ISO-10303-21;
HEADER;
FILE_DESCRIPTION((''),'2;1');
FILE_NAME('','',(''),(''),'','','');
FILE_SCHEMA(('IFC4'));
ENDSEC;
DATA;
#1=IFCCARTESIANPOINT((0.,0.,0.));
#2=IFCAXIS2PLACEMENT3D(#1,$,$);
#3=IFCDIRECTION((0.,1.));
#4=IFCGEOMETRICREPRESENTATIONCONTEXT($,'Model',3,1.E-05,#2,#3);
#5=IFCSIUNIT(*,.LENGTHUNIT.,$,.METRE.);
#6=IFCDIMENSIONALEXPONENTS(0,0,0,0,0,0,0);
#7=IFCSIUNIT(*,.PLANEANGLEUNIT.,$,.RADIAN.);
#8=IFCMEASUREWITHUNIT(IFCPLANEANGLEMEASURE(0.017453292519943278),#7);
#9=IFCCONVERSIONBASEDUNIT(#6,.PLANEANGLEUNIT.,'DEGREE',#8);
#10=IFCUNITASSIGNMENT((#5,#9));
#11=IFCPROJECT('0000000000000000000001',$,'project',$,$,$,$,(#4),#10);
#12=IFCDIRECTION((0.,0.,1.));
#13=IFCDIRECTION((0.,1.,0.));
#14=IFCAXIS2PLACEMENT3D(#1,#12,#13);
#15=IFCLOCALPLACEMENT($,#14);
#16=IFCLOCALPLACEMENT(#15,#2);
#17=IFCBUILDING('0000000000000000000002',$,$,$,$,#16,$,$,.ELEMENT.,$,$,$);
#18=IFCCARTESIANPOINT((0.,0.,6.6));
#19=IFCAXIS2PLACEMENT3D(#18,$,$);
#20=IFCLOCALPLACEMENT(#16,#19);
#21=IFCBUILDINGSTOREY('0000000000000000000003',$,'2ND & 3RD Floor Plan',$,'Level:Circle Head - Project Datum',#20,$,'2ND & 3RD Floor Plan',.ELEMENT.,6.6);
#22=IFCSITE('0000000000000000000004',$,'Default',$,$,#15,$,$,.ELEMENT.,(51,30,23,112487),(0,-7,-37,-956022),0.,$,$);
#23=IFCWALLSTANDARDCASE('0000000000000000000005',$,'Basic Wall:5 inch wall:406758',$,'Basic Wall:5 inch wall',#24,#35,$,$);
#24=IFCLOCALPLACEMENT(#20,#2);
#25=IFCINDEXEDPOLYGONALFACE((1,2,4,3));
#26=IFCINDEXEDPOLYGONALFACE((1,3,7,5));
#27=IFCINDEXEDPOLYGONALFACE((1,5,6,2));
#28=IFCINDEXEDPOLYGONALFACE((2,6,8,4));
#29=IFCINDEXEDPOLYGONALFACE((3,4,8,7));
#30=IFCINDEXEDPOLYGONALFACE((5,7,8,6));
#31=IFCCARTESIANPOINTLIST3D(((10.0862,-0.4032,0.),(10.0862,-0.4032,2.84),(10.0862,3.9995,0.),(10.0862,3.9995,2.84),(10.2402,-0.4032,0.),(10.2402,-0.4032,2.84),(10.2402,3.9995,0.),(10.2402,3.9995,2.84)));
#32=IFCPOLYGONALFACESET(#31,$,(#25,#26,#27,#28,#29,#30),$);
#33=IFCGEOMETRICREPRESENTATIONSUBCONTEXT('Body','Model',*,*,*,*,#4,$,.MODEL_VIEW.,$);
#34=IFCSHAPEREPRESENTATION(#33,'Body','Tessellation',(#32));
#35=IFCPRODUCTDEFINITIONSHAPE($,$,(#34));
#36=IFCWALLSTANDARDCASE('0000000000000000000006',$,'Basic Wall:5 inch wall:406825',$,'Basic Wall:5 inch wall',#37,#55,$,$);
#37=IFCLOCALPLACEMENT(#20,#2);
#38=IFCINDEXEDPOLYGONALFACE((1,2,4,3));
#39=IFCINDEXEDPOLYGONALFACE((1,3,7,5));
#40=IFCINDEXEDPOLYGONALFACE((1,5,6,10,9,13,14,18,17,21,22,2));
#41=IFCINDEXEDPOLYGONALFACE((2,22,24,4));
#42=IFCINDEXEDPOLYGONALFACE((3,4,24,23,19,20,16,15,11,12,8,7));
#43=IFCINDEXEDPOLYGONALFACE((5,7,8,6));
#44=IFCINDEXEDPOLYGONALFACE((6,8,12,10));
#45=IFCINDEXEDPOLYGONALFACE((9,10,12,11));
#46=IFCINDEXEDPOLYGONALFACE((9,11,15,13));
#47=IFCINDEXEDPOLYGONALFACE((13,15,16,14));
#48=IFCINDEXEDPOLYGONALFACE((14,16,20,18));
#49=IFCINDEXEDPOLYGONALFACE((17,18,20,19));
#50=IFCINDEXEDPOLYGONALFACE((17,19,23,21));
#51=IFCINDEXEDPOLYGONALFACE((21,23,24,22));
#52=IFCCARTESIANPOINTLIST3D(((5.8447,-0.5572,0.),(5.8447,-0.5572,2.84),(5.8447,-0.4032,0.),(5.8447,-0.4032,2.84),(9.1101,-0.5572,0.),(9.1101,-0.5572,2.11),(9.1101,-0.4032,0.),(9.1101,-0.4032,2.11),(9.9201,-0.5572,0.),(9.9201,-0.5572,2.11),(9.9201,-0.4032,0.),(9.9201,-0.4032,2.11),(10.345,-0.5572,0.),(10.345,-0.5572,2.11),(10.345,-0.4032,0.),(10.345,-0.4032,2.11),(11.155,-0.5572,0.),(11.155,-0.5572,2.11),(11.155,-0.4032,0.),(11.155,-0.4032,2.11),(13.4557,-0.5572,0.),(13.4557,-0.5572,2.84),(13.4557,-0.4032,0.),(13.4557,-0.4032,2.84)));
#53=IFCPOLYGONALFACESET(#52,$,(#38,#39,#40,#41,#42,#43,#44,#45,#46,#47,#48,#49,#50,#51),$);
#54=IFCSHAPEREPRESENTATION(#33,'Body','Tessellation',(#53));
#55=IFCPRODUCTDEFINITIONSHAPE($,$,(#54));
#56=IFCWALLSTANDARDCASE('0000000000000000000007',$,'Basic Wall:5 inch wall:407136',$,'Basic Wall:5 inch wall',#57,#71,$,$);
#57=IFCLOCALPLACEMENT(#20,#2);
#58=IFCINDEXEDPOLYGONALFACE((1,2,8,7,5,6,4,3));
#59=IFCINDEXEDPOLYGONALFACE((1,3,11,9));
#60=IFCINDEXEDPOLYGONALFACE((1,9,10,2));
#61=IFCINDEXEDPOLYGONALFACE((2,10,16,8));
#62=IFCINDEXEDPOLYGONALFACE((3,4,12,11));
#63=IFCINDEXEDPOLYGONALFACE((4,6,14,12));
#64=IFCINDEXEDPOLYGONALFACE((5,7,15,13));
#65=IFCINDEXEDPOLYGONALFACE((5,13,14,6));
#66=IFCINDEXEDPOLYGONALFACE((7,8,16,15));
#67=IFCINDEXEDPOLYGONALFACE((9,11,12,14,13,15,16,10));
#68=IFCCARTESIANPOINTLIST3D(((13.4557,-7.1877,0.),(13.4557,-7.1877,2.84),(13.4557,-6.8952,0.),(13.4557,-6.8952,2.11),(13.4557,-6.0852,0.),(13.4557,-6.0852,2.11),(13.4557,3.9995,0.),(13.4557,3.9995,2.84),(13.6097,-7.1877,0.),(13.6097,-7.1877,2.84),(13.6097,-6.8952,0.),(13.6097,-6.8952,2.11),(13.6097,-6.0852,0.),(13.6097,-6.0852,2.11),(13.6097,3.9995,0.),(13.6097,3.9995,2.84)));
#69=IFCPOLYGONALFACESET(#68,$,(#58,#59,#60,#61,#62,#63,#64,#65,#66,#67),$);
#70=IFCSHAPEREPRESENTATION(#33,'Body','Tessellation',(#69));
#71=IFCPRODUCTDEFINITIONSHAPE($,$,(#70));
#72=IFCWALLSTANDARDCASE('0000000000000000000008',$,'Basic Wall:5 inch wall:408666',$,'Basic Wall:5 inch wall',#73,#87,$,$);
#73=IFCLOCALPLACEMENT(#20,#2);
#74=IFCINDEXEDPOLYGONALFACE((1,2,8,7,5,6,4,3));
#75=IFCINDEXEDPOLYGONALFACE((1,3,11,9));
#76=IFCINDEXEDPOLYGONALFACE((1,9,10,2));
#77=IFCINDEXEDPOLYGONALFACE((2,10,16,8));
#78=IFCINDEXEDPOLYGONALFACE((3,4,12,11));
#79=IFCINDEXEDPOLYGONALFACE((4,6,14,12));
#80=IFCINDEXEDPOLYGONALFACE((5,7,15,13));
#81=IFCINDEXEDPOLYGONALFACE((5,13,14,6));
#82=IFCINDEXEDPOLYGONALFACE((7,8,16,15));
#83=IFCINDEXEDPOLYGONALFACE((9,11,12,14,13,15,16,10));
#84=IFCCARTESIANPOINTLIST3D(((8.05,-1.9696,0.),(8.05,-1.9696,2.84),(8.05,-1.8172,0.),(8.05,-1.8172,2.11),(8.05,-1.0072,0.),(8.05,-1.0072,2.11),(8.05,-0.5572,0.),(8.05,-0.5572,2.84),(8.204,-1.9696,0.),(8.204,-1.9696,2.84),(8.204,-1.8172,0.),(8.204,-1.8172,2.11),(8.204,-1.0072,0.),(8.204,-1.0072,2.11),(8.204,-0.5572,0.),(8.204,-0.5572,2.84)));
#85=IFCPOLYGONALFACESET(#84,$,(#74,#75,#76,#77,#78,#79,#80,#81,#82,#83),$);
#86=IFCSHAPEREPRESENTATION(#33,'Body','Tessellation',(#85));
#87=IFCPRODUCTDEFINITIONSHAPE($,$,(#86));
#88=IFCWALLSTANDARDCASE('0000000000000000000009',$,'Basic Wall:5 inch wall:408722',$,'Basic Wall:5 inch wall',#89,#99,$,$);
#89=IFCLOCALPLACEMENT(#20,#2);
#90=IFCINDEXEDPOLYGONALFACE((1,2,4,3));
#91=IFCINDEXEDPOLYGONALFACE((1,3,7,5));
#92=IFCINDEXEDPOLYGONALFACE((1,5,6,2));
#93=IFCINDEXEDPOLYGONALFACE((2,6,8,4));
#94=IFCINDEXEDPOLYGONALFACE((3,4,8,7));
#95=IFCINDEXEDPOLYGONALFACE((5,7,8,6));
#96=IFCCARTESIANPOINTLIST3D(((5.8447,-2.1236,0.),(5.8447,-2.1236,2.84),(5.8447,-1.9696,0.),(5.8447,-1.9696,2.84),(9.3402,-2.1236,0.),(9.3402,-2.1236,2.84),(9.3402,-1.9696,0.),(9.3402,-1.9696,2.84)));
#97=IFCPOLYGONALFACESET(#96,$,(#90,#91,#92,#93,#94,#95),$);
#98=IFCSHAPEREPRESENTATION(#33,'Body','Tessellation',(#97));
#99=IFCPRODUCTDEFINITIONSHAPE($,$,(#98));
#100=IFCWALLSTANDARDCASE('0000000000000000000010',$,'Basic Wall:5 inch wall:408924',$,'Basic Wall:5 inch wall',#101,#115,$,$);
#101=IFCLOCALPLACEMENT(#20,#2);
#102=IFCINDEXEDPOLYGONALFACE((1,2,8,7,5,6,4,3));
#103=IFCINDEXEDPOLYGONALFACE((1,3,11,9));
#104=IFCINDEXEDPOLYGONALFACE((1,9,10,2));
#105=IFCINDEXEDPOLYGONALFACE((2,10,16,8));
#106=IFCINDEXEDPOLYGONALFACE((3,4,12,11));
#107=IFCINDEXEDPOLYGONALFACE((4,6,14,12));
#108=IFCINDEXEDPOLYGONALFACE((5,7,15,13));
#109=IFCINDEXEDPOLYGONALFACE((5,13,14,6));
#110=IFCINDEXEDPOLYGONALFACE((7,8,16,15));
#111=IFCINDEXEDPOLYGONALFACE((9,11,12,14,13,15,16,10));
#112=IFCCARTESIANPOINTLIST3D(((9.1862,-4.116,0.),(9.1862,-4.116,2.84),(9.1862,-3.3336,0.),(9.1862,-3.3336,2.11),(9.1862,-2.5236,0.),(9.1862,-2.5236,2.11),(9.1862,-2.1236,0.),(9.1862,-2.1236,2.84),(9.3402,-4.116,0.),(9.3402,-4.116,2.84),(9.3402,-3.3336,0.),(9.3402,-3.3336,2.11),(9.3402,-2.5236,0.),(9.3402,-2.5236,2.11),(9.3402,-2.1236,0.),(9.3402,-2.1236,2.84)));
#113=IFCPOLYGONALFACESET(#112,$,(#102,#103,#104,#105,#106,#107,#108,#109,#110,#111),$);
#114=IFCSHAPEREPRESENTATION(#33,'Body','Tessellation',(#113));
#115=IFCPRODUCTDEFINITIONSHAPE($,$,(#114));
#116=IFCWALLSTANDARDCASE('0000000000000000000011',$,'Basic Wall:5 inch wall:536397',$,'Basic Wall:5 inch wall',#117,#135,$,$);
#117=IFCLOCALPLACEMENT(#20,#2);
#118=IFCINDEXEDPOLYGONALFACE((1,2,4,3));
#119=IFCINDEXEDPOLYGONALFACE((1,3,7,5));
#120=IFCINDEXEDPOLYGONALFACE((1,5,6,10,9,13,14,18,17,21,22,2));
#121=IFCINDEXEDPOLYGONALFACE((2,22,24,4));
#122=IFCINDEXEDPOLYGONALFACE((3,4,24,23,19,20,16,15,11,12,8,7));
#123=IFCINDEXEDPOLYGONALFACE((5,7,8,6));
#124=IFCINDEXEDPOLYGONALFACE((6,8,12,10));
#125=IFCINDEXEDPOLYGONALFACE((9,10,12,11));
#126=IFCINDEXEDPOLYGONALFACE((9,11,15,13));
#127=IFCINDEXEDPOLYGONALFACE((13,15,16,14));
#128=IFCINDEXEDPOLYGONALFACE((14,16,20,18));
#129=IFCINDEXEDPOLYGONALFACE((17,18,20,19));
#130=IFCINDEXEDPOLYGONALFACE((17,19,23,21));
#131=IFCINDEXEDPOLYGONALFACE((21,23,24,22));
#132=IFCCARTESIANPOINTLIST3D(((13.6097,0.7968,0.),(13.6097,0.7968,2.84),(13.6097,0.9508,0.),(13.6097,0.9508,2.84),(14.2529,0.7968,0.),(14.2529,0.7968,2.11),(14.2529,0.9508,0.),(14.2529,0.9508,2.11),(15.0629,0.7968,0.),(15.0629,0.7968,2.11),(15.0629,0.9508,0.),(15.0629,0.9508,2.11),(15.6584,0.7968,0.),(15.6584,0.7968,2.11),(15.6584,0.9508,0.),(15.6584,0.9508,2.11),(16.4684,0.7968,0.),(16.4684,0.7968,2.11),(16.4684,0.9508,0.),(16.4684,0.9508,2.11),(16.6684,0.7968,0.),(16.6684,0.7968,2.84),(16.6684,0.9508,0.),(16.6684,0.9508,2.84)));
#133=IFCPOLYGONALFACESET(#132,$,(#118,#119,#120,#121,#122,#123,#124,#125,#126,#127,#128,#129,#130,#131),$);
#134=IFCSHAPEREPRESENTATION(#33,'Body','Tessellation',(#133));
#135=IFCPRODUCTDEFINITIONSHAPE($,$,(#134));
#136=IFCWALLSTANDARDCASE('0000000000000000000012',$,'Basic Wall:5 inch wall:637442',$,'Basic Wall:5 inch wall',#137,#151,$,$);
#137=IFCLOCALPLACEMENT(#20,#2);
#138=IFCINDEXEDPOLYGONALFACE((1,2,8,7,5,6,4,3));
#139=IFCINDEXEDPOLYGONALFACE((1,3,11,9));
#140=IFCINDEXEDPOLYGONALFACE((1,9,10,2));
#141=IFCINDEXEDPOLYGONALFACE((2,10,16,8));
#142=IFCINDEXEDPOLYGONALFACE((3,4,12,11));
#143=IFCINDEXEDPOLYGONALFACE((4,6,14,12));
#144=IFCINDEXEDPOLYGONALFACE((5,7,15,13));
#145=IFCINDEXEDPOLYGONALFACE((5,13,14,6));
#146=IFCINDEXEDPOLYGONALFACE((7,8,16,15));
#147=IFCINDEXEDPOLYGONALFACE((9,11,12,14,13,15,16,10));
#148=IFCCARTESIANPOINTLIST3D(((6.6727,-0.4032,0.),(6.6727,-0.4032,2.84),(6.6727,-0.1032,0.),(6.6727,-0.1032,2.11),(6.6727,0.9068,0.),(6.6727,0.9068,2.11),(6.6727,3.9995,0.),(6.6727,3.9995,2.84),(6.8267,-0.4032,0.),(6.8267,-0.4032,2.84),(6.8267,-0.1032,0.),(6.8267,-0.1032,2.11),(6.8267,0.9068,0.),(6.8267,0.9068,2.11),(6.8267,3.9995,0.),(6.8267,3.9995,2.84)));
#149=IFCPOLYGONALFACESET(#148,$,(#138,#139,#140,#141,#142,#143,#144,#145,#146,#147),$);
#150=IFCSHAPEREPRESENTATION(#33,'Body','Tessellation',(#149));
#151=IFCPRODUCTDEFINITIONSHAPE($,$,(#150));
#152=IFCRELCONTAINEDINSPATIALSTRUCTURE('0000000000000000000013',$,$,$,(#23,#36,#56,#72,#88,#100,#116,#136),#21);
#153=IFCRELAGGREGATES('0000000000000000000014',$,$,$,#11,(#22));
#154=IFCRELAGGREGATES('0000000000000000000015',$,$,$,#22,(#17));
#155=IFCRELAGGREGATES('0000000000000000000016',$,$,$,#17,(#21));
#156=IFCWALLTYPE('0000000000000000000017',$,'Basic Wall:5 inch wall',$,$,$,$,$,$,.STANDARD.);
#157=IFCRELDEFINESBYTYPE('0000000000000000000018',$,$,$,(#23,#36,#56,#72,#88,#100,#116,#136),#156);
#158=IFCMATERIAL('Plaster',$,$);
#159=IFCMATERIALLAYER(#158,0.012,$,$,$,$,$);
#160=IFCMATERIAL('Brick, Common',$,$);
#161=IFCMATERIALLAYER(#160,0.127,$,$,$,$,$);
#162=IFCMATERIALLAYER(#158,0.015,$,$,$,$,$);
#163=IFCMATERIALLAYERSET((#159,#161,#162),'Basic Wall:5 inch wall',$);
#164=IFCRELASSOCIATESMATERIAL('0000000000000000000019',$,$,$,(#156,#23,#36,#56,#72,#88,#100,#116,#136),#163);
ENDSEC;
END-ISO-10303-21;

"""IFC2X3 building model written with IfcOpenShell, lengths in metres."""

from ifc_helpers import new_model, entity, si_unit, converted_unit, direction, frame, frame_2d, origin, place, context, subcontext, project, spatial, rectangle, extrude, material, layer, layer_set, layer_usage, type_object, element, save


model = new_model("IFC2X3")

# Units and contexts
model_context = context("Model", 3, precision=1e-05, world=origin(), true_north=direction((0.0, 1.0)))
body_context = subcontext(model_context, "Body", "Model", "MODEL_VIEW")
ifc_project = project(units=[si_unit("LENGTHUNIT", "METRE"), converted_unit("PLANEANGLEUNIT", "DEGREE", entity("IfcPlaneAngleMeasure", 0.017453292519943278), si_unit("PLANEANGLEUNIT", "RADIAN"), dimensions=[0, 0, 0, 0, 0, 0, 0])], contexts=[model_context])

# Site, building, storey
site_placement = place(None, frame((0.0, 0.0, 0.0), z_axis=(0.0, 0.0, 1.0), x_axis=(0.0, 1.0, 0.0)))
site = spatial("IfcSite", under=ifc_project, at=site_placement, Name="Default", CompositionType="ELEMENT", RefLatitude=(51, 30, 23, 112487), RefLongitude=(0, -7, -37, -956022), RefElevation=0.0)
building_placement = place(site_placement, origin())
building = spatial("IfcBuilding", under=site, at=building_placement, CompositionType="ELEMENT")
storey_placement = place(building_placement, frame((0.0, 0.0, 6.6)))
storey = spatial("IfcBuildingStorey", under=building, at=storey_placement, Name="2ND & 3RD Floor Plan", ObjectType="Level:Circle Head - Project Datum", LongName="2ND & 3RD Floor Plan", CompositionType="ELEMENT", Elevation=6.6)

# Wall
ifc_material_1 = material(Name="Plaster")
ifc_layer_1 = layer(ifc_material_1, 0.012)
ifc_material_2 = material(Name="Brick, Common")
ifc_layer_2 = layer(ifc_material_2, 0.127)
ifc_layer_3 = layer(ifc_material_1, 0.015)
ifc_layer_set = layer_set([ifc_layer_1, ifc_layer_2, ifc_layer_3], Name="Basic Wall:5 inch wall")
ifc_layer_usage_1 = layer_usage(ifc_layer_set, "AXIS2", "NEGATIVE", 0.077)
wall_type = type_object("IfcWallType", Name="Basic Wall:5 inch wall", PredefinedType="STANDARD", material=ifc_layer_set)
wall_1_placement = place(storey_placement, frame((10.1632, 3.9995, 0.0), z_axis=(0.0, 0.0, 1.0), x_axis=(0.0, -1.0, 0.0)))
element("IfcWallStandardCase", 1, at=wall_1_placement, inside=storey, type_object=wall_type, material=ifc_layer_usage_1, Name="Basic Wall:5 inch wall:406758", ObjectType="Basic Wall:5 inch wall", context=body_context, shape_type="SweptSolid", body=[
    extrude(rectangle(XDim=4.4027, YDim=0.154, at=frame_2d((2.2014, 0.0), x_axis=(-1.0, 0.0))), origin(), (0.0, 0.0, 1.0), 2.84),
])

# Wall, openings
ifc_layer_usage_2 = layer_usage(ifc_layer_set, "AXIS2", "NEGATIVE", 0.077)
wall_2_placement = place(storey_placement, frame((13.4557, -0.4802, 0.0), z_axis=(0.0, 0.0, 1.0), x_axis=(-1.0, 0.0, 0.0)))
wall_2 = element("IfcWallStandardCase", 2, at=wall_2_placement, inside=storey, type_object=wall_type, material=ifc_layer_usage_2, Name="Basic Wall:5 inch wall:406825", ObjectType="Basic Wall:5 inch wall", context=body_context, shape_type="SweptSolid", body=[
    extrude(rectangle(XDim=7.611, YDim=0.154, at=frame_2d((3.8055, 0.0), x_axis=(-1.0, 0.0))), origin(), (0.0, 0.0, 1.0), 2.84),
])
opening_1_placement = place(wall_2_placement, frame((4.3456, 0.077, 0.0)))
element("IfcOpeningElement", 3, at=opening_1_placement, cuts=wall_2, ObjectType="Opening", context=body_context, shape_type="SweptSolid", body=[
    extrude(rectangle(XDim=2.11, YDim=0.81, at=frame_2d((1.055, 0.405), x_axis=(1.0, 0.0))), frame((0.0, 0.0, 0.0), z_axis=(0.0, -1.0, 0.0), x_axis=(0.0, 0.0, 1.0)), (0.0, 0.0, 1.0), 0.154),
])
opening_2_placement = place(wall_2_placement, frame((3.1107, 0.077, 0.0)))
element("IfcOpeningElement", 4, at=opening_2_placement, cuts=wall_2, ObjectType="Opening", context=body_context, shape_type="SweptSolid", body=[
    extrude(rectangle(XDim=2.11, YDim=0.81, at=frame_2d((1.055, 0.405), x_axis=(1.0, 0.0))), frame((0.0, 0.0, 0.0), z_axis=(0.0, -1.0, 0.0), x_axis=(0.0, 0.0, 1.0)), (0.0, 0.0, 1.0), 0.154),
])

# Walls, openings
ifc_layer_usage_3 = layer_usage(ifc_layer_set, "AXIS2", "NEGATIVE", 0.077)
wall_3_placement = place(storey_placement, frame((13.5327, 3.9995, 0.0), z_axis=(0.0, 0.0, 1.0), x_axis=(0.0, -1.0, 0.0)))
wall_3 = element("IfcWallStandardCase", 5, at=wall_3_placement, inside=storey, type_object=wall_type, material=ifc_layer_usage_3, Name="Basic Wall:5 inch wall:407136", ObjectType="Basic Wall:5 inch wall", context=body_context, shape_type="SweptSolid", body=[
    extrude(rectangle(XDim=11.1872, YDim=0.154, at=frame_2d((5.5936, 0.0), x_axis=(-1.0, 0.0))), origin(), (0.0, 0.0, 1.0), 2.84),
])
opening_3_placement = place(wall_3_placement, frame((10.0847, -0.077, 0.0)))
element("IfcOpeningElement", 6, at=opening_3_placement, cuts=wall_3, ObjectType="Opening", context=body_context, shape_type="SweptSolid", body=[
    extrude(rectangle(XDim=2.11, YDim=0.81, at=frame_2d((1.055, 0.405), x_axis=(1.0, 0.0))), frame((0.0, 0.0, 0.0), z_axis=(0.0, 1.0, 0.0), x_axis=(0.0, 0.0, 1.0)), (0.0, 0.0, 1.0), 0.154),
])
ifc_layer_usage_4 = layer_usage(ifc_layer_set, "AXIS2", "NEGATIVE", 0.077)
wall_4_placement = place(storey_placement, frame((8.127, -0.5572, 0.0), z_axis=(0.0, 0.0, 1.0), x_axis=(0.0, -1.0, 0.0)))
wall_4 = element("IfcWallStandardCase", 7, at=wall_4_placement, inside=storey, type_object=wall_type, material=ifc_layer_usage_4, Name="Basic Wall:5 inch wall:408666", ObjectType="Basic Wall:5 inch wall", context=body_context, shape_type="SweptSolid", body=[
    extrude(rectangle(XDim=1.4124, YDim=0.154, at=frame_2d((0.7062, 0.0), x_axis=(-1.0, 0.0))), origin(), (0.0, 0.0, 1.0), 2.84),
])
opening_4_placement = place(wall_4_placement, frame((1.26, 0.077, 0.0)))
element("IfcOpeningElement", 8, at=opening_4_placement, cuts=wall_4, ObjectType="Opening", context=body_context, shape_type="SweptSolid", body=[
    extrude(rectangle(XDim=2.11, YDim=0.81, at=frame_2d((1.055, 0.405), x_axis=(1.0, 0.0))), frame((0.0, 0.0, 0.0), z_axis=(0.0, -1.0, 0.0), x_axis=(0.0, 0.0, 1.0)), (0.0, 0.0, 1.0), 0.154),
])

# Wall
ifc_layer_usage_5 = layer_usage(ifc_layer_set, "AXIS2", "NEGATIVE", 0.077)
wall_5_placement = place(storey_placement, frame((9.3402, -2.0466, 0.0), z_axis=(0.0, 0.0, 1.0), x_axis=(-1.0, 0.0, 0.0)))
element("IfcWallStandardCase", 9, at=wall_5_placement, inside=storey, type_object=wall_type, material=ifc_layer_usage_5, Name="Basic Wall:5 inch wall:408722", ObjectType="Basic Wall:5 inch wall", context=body_context, shape_type="SweptSolid", body=[
    extrude(rectangle(XDim=3.4955, YDim=0.154, at=frame_2d((1.7478, 0.0), x_axis=(-1.0, 0.0))), origin(), (0.0, 0.0, 1.0), 2.84),
])

# Wall, opening
ifc_layer_usage_6 = layer_usage(ifc_layer_set, "AXIS2", "NEGATIVE", 0.077)
wall_6_placement = place(storey_placement, frame((9.2632, -2.1236, 0.0), z_axis=(0.0, 0.0, 1.0), x_axis=(0.0, -1.0, 0.0)))
wall_6 = element("IfcWallStandardCase", 10, at=wall_6_placement, inside=storey, type_object=wall_type, material=ifc_layer_usage_6, Name="Basic Wall:5 inch wall:408924", ObjectType="Basic Wall:5 inch wall", context=body_context, shape_type="SweptSolid", body=[
    extrude(rectangle(XDim=1.9924, YDim=0.154, at=frame_2d((0.9962, 0.0), x_axis=(-1.0, 0.0))), origin(), (0.0, 0.0, 1.0), 2.84),
])
opening_5_placement = place(wall_6_placement, frame((1.21, 0.077, 0.0)))
element("IfcOpeningElement", 11, at=opening_5_placement, cuts=wall_6, ObjectType="Opening", context=body_context, shape_type="SweptSolid", body=[
    extrude(rectangle(XDim=2.11, YDim=0.81, at=frame_2d((1.055, 0.405), x_axis=(1.0, 0.0))), frame((0.0, 0.0, 0.0), z_axis=(0.0, -1.0, 0.0), x_axis=(0.0, 0.0, 1.0)), (0.0, 0.0, 1.0), 0.154),
])

# Wall, openings
ifc_layer_usage_7 = layer_usage(ifc_layer_set, "AXIS2", "NEGATIVE", 0.077)
wall_7_placement = place(storey_placement, frame((13.6097, 0.8738, 0.0)))
wall_7 = element("IfcWallStandardCase", 12, at=wall_7_placement, inside=storey, type_object=wall_type, material=ifc_layer_usage_7, Name="Basic Wall:5 inch wall:536397", ObjectType="Basic Wall:5 inch wall", context=body_context, shape_type="SweptSolid", body=[
    extrude(rectangle(XDim=3.0586, YDim=0.154, at=frame_2d((1.5293, 0.0), x_axis=(-1.0, 0.0))), origin(), (0.0, 0.0, 1.0), 2.84),
])
opening_6_placement = place(wall_7_placement, frame((1.4532, 0.077, 0.0)))
element("IfcOpeningElement", 13, at=opening_6_placement, cuts=wall_7, ObjectType="Opening", context=body_context, shape_type="SweptSolid", body=[
    extrude(rectangle(XDim=2.11, YDim=0.81, at=frame_2d((1.055, 0.405), x_axis=(1.0, 0.0))), frame((0.0, 0.0, 0.0), z_axis=(0.0, -1.0, 0.0), x_axis=(0.0, 0.0, 1.0)), (0.0, 0.0, 1.0), 0.154),
])
opening_7_placement = place(wall_7_placement, frame((2.0486, -0.077, 0.0)))
element("IfcOpeningElement", 14, at=opening_7_placement, cuts=wall_7, ObjectType="Opening", context=body_context, shape_type="SweptSolid", body=[
    extrude(rectangle(XDim=2.11, YDim=0.81, at=frame_2d((1.055, 0.405), x_axis=(1.0, 0.0))), frame((0.0, 0.0, 0.0), z_axis=(0.0, 1.0, 0.0), x_axis=(0.0, 0.0, 1.0)), (0.0, 0.0, 1.0), 0.154),
])

# Wall, opening
ifc_layer_usage_8 = layer_usage(ifc_layer_set, "AXIS2", "NEGATIVE", 0.077)
wall_8_placement = place(storey_placement, frame((6.7497, 3.9995, 0.0), z_axis=(0.0, 0.0, 1.0), x_axis=(0.0, -1.0, 0.0)))
wall_8 = element("IfcWallStandardCase", 15, at=wall_8_placement, inside=storey, type_object=wall_type, material=ifc_layer_usage_8, Name="Basic Wall:5 inch wall:637442", ObjectType="Basic Wall:5 inch wall", context=body_context, shape_type="SweptSolid", body=[
    extrude(rectangle(XDim=4.4027, YDim=0.154, at=frame_2d((2.2014, 0.0), x_axis=(-1.0, 0.0))), origin(), (0.0, 0.0, 1.0), 2.84),
])
opening_8_placement = place(wall_8_placement, frame((3.0927, -0.077, 0.0)))
element("IfcOpeningElement", 16, at=opening_8_placement, cuts=wall_8, ObjectType="Opening", context=body_context, shape_type="SweptSolid", body=[
    extrude(rectangle(XDim=2.11, YDim=1.01, at=frame_2d((1.055, 0.505), x_axis=(1.0, 0.0))), frame((0.0, 0.0, 0.0), z_axis=(0.0, 1.0, 0.0), x_axis=(0.0, 0.0, 1.0)), (0.0, 0.0, 1.0), 0.154),
])

save(model, "model.ifc")
